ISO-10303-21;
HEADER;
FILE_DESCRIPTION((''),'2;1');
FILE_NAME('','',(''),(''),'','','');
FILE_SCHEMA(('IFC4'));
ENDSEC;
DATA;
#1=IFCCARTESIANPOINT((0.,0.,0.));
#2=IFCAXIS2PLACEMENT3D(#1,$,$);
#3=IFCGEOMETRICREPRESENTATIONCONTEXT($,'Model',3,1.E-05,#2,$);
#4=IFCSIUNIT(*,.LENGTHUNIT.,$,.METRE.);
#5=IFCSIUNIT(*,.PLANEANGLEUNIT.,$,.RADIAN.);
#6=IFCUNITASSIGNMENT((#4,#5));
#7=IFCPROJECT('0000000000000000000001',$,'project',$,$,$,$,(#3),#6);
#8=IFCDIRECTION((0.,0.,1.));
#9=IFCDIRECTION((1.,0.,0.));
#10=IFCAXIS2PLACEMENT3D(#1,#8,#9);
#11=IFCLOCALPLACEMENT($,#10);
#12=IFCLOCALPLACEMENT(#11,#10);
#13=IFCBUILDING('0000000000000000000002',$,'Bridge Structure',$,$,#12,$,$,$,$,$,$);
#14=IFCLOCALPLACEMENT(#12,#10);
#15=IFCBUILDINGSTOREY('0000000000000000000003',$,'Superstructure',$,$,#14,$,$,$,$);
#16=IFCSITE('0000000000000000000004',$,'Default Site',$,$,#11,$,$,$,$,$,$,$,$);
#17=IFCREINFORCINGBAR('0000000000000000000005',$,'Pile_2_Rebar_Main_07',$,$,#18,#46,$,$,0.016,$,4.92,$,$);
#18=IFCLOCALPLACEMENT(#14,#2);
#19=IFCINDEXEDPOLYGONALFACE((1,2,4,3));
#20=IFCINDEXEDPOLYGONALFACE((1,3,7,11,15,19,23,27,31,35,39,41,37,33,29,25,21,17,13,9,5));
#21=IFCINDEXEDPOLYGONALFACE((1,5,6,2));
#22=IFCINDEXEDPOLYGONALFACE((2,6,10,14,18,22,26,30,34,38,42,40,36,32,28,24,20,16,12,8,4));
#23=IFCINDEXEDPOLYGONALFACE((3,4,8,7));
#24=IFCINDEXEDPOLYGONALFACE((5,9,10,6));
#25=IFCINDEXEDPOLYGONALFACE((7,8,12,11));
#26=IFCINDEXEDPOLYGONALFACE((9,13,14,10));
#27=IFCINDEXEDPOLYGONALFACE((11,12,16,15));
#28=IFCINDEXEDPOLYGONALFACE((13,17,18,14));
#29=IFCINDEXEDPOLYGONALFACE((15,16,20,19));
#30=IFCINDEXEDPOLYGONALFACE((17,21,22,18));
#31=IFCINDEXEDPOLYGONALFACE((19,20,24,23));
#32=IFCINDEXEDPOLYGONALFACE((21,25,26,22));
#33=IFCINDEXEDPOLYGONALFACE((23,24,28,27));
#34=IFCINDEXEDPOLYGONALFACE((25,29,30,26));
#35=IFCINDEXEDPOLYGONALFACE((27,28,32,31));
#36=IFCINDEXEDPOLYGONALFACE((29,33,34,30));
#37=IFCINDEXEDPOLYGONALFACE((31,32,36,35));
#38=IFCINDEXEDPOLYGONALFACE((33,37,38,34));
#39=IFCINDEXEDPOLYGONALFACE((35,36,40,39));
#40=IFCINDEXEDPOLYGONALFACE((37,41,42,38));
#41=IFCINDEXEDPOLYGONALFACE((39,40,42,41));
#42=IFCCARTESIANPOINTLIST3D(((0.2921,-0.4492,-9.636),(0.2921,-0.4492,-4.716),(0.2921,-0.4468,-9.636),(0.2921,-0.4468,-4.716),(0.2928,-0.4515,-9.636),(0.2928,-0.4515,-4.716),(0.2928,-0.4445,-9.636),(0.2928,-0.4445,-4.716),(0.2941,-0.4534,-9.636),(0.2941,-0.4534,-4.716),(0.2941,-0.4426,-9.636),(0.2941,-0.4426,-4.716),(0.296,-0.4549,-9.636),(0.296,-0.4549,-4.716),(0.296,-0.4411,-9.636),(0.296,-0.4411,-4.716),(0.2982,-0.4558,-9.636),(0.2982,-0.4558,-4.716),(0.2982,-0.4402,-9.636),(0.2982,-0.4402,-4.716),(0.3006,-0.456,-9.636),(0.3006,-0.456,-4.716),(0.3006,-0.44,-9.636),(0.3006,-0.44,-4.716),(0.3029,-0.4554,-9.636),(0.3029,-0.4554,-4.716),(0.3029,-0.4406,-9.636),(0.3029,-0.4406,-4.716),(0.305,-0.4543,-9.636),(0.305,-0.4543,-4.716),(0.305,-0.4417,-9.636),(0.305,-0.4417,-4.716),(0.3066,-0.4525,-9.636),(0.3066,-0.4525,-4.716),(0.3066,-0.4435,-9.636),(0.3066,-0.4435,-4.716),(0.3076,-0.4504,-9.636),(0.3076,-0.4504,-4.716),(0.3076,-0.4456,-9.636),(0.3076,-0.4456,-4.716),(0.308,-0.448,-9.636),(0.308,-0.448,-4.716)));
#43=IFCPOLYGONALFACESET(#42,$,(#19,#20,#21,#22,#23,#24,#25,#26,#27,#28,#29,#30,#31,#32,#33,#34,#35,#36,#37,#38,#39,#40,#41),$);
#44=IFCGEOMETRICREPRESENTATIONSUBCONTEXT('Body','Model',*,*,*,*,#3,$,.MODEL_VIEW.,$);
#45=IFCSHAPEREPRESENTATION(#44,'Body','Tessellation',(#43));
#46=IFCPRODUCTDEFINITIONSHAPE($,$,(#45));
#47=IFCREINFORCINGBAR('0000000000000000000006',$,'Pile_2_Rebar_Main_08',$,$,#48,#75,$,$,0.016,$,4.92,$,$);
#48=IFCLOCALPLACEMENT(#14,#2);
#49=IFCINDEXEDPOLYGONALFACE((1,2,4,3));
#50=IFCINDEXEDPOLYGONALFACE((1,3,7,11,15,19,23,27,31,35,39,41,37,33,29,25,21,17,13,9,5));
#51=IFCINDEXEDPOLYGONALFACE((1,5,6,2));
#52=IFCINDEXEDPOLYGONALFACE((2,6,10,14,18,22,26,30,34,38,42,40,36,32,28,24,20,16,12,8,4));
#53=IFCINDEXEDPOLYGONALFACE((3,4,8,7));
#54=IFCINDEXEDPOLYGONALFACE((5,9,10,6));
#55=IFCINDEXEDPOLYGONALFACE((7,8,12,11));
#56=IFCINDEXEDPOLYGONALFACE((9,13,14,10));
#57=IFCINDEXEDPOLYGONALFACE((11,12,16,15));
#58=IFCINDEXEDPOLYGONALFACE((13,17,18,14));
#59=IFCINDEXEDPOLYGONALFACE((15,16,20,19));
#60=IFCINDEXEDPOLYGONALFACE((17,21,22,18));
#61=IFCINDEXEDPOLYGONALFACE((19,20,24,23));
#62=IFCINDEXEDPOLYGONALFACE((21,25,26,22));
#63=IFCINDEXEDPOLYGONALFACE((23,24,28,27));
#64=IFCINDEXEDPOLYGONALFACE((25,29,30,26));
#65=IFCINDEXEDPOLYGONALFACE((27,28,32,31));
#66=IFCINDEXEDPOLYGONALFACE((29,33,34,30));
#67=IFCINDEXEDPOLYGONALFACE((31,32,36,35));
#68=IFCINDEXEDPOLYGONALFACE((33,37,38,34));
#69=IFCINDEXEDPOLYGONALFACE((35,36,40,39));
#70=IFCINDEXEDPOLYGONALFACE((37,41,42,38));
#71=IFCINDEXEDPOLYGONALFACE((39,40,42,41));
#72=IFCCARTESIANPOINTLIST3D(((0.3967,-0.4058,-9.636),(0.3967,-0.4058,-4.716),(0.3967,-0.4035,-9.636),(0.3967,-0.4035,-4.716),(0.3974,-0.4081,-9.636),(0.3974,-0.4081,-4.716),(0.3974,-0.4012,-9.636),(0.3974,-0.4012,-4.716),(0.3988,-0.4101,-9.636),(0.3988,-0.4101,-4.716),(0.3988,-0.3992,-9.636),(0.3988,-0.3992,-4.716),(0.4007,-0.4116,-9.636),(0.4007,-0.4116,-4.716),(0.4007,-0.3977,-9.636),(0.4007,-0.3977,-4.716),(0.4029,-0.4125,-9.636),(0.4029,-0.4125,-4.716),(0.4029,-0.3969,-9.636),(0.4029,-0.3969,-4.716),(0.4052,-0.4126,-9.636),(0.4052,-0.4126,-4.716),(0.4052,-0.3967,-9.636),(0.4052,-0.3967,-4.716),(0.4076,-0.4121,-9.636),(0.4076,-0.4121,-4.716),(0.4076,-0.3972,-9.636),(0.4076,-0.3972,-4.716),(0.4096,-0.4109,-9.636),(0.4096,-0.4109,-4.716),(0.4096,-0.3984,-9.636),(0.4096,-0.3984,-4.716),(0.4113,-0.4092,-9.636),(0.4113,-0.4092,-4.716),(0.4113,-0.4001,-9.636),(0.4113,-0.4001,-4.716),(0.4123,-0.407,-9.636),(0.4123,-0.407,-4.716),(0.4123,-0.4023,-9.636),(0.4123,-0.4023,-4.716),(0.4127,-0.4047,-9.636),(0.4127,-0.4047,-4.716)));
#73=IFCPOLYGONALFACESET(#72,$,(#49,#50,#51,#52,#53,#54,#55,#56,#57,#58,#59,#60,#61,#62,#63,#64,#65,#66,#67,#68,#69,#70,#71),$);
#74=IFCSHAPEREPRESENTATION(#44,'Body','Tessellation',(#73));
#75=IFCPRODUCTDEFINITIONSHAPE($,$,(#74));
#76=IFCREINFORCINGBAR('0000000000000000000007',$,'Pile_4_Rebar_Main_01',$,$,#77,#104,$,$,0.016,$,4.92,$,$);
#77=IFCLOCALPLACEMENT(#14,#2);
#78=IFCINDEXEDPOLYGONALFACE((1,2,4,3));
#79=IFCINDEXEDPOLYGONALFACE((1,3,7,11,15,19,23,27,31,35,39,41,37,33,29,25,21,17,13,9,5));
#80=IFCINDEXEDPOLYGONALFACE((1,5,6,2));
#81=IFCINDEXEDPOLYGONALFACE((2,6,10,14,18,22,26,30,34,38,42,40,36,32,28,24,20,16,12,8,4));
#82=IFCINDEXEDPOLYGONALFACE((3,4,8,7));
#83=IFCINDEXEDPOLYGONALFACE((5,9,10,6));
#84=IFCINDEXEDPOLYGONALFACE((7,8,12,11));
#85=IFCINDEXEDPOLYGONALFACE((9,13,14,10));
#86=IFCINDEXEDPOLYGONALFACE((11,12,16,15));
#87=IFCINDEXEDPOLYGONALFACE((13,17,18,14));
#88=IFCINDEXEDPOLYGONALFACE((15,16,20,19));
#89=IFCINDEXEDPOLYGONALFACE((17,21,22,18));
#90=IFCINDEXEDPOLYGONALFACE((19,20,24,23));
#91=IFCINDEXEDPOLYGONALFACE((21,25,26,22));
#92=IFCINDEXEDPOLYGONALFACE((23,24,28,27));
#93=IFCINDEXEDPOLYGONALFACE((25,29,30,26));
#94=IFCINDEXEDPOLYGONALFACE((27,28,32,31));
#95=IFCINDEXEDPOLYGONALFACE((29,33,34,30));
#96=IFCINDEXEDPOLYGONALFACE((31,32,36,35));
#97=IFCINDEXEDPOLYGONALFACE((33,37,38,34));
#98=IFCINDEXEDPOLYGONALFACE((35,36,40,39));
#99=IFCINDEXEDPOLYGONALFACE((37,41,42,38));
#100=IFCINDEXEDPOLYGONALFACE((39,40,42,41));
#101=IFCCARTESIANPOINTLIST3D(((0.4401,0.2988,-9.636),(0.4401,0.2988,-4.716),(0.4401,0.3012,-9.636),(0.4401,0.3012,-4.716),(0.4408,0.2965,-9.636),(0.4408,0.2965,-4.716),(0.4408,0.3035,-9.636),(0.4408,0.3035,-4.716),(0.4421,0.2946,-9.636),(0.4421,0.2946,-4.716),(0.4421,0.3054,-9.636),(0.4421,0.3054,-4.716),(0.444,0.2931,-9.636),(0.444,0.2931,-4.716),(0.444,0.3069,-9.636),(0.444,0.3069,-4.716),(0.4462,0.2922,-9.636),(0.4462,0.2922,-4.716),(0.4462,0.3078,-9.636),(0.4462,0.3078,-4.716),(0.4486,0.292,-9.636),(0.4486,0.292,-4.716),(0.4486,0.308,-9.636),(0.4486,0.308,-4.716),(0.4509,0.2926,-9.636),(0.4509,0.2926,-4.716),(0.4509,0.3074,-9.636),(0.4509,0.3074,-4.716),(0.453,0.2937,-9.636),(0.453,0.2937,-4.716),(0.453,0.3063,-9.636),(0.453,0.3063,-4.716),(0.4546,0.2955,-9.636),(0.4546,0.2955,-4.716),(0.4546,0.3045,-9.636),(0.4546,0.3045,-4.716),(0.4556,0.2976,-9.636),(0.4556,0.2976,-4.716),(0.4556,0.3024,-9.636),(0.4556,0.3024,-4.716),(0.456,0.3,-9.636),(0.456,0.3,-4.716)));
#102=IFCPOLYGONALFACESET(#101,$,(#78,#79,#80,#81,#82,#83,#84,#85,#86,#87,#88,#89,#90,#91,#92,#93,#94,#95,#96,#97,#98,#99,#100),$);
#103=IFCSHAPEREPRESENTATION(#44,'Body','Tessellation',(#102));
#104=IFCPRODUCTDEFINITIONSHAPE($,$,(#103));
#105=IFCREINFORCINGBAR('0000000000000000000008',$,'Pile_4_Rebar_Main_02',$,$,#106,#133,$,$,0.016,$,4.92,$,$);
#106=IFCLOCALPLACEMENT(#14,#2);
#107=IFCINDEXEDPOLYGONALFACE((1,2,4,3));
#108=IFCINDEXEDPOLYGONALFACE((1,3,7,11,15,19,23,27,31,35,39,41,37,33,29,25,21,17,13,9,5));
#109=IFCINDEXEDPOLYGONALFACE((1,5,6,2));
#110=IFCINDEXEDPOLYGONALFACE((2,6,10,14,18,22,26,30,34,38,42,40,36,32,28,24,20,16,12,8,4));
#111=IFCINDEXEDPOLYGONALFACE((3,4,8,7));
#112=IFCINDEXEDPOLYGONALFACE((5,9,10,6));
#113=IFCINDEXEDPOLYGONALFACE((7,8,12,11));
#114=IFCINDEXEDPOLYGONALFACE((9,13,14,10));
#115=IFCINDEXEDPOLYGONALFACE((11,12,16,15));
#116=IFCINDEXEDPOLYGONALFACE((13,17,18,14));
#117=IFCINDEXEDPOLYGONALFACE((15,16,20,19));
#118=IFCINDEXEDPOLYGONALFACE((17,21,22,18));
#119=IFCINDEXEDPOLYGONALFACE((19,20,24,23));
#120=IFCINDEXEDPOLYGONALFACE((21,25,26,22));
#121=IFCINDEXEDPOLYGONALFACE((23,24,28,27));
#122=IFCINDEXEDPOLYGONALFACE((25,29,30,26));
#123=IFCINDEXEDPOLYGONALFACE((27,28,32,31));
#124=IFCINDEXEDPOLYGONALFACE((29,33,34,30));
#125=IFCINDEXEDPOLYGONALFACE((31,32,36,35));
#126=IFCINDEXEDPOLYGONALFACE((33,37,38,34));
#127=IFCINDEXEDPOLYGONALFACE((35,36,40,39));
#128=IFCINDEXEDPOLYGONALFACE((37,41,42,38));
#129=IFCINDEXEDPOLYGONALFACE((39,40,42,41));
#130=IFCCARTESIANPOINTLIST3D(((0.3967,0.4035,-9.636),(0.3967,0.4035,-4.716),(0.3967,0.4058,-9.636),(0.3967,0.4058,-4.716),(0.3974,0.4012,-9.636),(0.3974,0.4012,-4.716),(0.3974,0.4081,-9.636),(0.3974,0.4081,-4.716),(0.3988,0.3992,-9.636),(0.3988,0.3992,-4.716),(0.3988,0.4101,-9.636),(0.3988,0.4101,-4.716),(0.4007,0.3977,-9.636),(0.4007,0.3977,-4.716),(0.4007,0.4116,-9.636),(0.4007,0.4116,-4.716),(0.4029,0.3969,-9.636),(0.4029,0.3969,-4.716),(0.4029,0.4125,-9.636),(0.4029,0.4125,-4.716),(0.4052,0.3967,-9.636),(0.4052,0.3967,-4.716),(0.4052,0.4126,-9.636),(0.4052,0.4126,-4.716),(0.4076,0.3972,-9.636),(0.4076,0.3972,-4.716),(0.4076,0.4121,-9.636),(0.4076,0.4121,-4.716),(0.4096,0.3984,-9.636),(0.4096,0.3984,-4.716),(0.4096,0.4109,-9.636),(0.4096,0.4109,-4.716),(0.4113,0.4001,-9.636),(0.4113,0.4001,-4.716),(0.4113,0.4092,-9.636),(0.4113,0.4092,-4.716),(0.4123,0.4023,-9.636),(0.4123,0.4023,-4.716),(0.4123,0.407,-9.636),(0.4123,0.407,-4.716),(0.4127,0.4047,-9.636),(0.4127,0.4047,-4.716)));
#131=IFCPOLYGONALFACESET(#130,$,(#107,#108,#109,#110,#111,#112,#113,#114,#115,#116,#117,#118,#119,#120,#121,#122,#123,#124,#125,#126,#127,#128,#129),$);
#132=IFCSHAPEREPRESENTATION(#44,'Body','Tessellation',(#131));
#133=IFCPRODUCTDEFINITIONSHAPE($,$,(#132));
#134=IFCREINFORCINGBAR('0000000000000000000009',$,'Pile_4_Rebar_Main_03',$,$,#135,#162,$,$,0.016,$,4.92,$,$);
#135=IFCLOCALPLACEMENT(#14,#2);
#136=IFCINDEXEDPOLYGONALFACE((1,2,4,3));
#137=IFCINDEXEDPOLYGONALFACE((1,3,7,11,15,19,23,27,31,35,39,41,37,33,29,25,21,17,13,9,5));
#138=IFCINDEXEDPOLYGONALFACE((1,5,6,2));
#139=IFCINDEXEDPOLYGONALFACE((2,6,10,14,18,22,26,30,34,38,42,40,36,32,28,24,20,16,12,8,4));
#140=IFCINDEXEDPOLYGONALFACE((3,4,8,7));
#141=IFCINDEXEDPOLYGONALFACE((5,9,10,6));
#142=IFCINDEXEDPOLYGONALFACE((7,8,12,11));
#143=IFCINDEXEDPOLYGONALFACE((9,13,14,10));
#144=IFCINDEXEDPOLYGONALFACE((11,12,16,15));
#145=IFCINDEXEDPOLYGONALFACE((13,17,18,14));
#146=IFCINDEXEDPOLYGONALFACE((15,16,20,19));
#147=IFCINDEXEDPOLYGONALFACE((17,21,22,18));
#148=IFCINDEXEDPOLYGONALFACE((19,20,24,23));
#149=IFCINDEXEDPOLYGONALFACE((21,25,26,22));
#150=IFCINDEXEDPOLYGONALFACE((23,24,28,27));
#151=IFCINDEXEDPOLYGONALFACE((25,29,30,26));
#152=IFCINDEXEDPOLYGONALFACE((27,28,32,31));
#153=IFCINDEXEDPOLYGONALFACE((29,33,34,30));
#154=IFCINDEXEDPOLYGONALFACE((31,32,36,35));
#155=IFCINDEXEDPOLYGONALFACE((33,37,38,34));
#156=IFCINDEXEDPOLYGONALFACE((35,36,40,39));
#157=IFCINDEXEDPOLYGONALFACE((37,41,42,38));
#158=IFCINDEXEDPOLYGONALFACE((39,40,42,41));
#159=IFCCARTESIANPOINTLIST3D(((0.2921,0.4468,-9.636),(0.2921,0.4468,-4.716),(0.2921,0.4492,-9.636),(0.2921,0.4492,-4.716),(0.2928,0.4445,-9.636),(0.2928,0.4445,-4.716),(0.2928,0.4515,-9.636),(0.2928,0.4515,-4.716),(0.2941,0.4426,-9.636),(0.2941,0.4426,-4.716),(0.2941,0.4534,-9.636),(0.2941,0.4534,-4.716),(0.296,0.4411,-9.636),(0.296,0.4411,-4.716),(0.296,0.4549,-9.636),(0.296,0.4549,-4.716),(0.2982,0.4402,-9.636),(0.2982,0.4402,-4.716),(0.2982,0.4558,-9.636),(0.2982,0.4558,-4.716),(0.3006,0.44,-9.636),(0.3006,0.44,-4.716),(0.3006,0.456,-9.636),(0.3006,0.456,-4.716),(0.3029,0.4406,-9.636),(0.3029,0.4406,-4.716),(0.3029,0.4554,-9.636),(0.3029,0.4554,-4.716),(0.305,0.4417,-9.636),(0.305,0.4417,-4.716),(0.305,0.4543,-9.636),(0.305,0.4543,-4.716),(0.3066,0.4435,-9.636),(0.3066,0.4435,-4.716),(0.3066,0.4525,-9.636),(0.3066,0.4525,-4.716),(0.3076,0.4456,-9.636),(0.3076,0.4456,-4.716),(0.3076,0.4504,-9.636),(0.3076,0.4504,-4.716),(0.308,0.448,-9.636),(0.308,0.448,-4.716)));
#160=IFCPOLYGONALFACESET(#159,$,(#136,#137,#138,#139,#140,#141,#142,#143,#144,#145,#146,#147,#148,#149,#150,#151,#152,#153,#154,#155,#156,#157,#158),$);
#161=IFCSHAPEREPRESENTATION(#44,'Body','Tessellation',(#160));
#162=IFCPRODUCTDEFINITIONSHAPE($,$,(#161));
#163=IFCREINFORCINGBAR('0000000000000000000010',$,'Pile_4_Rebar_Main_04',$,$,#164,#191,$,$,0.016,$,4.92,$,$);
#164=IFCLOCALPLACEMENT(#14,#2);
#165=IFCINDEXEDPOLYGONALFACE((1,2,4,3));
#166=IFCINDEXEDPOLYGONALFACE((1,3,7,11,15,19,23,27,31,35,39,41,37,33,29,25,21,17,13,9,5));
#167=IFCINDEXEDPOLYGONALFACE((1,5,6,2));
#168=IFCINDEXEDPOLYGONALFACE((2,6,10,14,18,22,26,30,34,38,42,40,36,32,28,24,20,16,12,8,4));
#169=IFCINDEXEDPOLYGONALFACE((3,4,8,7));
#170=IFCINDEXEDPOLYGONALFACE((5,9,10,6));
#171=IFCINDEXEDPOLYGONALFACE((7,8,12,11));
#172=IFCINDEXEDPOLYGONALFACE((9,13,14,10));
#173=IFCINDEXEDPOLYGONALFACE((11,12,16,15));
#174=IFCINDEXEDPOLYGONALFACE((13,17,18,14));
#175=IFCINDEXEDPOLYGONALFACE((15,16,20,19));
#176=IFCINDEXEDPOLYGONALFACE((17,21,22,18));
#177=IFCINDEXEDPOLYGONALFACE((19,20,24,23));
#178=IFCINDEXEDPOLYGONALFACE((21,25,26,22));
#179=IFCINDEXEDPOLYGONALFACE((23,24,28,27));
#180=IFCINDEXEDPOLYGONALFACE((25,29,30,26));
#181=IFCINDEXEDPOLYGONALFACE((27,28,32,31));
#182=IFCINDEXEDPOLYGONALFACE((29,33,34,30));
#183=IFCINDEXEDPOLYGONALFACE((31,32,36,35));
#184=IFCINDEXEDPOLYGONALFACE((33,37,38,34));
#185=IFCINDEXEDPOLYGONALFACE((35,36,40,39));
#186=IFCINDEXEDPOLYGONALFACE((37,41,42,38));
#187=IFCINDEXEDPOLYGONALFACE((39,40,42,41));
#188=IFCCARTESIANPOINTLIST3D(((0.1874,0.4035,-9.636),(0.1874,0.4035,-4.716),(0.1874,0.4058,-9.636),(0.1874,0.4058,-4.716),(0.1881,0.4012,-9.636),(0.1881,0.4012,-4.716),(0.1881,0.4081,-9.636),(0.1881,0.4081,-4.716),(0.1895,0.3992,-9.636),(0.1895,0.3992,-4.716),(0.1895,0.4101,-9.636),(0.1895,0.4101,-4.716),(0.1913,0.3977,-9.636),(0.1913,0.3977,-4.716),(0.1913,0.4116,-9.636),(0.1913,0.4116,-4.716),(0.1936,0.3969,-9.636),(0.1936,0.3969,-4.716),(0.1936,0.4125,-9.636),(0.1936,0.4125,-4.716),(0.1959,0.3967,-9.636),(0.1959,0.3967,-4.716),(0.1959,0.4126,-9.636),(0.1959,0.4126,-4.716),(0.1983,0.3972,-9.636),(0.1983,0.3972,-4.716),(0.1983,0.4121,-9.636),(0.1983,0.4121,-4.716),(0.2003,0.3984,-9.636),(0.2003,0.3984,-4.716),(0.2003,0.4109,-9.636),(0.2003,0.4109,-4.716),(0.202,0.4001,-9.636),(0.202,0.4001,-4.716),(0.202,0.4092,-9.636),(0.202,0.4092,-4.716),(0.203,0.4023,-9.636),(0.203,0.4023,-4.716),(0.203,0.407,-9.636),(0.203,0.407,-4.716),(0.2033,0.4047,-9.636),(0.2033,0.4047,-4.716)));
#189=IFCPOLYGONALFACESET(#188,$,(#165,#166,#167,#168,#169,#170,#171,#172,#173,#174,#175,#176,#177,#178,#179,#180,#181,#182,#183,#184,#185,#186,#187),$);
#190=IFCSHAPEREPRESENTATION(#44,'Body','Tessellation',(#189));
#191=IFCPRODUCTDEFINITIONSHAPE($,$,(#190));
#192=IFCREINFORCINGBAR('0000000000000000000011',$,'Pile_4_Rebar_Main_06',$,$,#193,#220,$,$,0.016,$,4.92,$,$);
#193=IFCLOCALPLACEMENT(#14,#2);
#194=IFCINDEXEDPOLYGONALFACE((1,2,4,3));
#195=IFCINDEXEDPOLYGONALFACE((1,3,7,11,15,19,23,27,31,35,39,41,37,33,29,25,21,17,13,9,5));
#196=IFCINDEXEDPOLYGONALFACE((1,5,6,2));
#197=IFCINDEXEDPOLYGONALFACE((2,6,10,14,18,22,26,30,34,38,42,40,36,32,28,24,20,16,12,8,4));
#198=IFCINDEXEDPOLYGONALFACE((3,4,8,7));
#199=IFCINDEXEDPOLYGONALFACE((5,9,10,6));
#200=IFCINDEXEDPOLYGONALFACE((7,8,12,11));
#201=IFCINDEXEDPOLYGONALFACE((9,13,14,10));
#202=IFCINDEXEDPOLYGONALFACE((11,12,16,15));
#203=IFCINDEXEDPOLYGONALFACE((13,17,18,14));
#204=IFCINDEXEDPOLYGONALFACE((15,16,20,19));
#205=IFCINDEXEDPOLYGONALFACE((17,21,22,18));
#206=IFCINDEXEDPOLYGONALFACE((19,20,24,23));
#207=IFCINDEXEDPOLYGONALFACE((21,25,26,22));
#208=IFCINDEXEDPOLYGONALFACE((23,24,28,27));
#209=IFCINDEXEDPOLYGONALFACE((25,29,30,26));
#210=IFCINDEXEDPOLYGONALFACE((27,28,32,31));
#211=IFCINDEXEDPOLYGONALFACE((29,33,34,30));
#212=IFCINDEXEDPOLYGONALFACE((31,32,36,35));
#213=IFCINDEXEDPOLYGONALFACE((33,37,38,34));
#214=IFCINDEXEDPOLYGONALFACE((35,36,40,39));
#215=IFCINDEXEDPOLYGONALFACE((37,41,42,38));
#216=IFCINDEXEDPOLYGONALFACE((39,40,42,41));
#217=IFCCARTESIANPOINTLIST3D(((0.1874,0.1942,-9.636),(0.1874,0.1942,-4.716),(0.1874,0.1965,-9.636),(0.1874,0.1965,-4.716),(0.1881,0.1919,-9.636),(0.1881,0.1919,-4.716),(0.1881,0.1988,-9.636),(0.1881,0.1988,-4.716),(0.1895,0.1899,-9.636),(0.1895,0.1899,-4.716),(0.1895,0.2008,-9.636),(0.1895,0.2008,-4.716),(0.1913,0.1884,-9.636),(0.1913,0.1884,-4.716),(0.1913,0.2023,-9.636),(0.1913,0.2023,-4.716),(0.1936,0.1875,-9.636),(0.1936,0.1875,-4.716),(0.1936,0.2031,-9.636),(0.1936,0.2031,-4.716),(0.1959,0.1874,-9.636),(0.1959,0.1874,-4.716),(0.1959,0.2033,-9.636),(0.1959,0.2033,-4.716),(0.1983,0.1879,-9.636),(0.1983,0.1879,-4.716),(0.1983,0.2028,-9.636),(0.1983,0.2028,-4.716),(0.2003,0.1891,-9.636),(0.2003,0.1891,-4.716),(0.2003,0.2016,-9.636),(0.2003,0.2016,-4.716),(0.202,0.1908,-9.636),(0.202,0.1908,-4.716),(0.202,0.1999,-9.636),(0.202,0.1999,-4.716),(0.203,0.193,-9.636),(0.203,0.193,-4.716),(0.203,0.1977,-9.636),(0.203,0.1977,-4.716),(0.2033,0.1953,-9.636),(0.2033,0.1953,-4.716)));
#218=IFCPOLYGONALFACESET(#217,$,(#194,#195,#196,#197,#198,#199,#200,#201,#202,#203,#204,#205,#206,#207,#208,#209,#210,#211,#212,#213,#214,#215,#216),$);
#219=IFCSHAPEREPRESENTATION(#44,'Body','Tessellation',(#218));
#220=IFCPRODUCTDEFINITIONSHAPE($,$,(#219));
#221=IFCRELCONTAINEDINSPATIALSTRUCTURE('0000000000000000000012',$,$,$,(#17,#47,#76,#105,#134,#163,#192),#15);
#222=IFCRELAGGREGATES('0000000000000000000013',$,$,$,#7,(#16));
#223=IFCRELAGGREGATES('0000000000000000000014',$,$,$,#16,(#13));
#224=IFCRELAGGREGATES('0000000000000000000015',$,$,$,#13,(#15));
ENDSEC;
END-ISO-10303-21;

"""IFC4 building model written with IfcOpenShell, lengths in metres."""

from ifc_helpers import new_model, si_unit, frame, origin, origin_with_axes, origin_2d_with_axis, place, context, subcontext, project, spatial, circle, extrude, element, save


model = new_model("IFC4")

# Units and contexts
model_context = context("Model", 3, precision=1e-05, world=origin())
body_context = subcontext(model_context, "Body", "Model", "MODEL_VIEW")
ifc_project = project(units=[si_unit("LENGTHUNIT", "METRE"), si_unit("PLANEANGLEUNIT", "RADIAN")], contexts=[model_context])

# Site, building, storey
site_placement = place(None, origin_with_axes())
site = spatial("IfcSite", under=ifc_project, at=site_placement, Name="Default Site")
building_placement = place(site_placement, origin_with_axes())
building = spatial("IfcBuilding", under=site, at=building_placement, Name="Bridge Structure")
storey_placement = place(building_placement, origin_with_axes())
storey = spatial("IfcBuildingStorey", under=building, at=storey_placement, Name="Superstructure")

# Reinforcing bars
for number, where, z_axis, x_axis, name in (
    (1, (0.3, -0.448, -9.636), (0.0, 0.0, 1.0), (1.0, 0.0, 0.0), "Pile_2_Rebar_Main_07"),
    (2, (0.4047, -0.4047, -9.636), (0.0, 0.0, 1.0), (1.0, 0.0, 0.0), "Pile_2_Rebar_Main_08"),
    (3, (0.448, 0.3, -9.636), (0.0, 0.0, 1.0), (1.0, 0.0, 0.0), "Pile_4_Rebar_Main_01"),
    (4, (0.4047, 0.4047, -9.636), (0.0, 0.0, 1.0), (1.0, 0.0, 0.0), "Pile_4_Rebar_Main_02"),
    (5, (0.3, 0.448, -9.636), (0.0, 0.0, 1.0), (1.0, 0.0, 0.0), "Pile_4_Rebar_Main_03"),
    (6, (0.1953, 0.4047, -9.636), (0.0, 0.0, 1.0), (1.0, 0.0, 0.0), "Pile_4_Rebar_Main_04"),
    (7, (0.1953, 0.1953, -9.636), (0.0, 0.0, 1.0), (1.0, 0.0, 0.0), "Pile_4_Rebar_Main_06"),
):
    element("IfcReinforcingBar", number, at=place(storey_placement, frame(where, z_axis=z_axis, x_axis=x_axis)), inside=storey, Name=name, BarLength=4.92, NominalDiameter=0.016, context=body_context, shape_type="SweptSolid", body=[
        extrude(circle(Radius=0.008, at=origin_2d_with_axis()), origin_with_axes(), (0.0, 0.0, 1.0), 4.92),
    ])

save(model, "model.ifc")
